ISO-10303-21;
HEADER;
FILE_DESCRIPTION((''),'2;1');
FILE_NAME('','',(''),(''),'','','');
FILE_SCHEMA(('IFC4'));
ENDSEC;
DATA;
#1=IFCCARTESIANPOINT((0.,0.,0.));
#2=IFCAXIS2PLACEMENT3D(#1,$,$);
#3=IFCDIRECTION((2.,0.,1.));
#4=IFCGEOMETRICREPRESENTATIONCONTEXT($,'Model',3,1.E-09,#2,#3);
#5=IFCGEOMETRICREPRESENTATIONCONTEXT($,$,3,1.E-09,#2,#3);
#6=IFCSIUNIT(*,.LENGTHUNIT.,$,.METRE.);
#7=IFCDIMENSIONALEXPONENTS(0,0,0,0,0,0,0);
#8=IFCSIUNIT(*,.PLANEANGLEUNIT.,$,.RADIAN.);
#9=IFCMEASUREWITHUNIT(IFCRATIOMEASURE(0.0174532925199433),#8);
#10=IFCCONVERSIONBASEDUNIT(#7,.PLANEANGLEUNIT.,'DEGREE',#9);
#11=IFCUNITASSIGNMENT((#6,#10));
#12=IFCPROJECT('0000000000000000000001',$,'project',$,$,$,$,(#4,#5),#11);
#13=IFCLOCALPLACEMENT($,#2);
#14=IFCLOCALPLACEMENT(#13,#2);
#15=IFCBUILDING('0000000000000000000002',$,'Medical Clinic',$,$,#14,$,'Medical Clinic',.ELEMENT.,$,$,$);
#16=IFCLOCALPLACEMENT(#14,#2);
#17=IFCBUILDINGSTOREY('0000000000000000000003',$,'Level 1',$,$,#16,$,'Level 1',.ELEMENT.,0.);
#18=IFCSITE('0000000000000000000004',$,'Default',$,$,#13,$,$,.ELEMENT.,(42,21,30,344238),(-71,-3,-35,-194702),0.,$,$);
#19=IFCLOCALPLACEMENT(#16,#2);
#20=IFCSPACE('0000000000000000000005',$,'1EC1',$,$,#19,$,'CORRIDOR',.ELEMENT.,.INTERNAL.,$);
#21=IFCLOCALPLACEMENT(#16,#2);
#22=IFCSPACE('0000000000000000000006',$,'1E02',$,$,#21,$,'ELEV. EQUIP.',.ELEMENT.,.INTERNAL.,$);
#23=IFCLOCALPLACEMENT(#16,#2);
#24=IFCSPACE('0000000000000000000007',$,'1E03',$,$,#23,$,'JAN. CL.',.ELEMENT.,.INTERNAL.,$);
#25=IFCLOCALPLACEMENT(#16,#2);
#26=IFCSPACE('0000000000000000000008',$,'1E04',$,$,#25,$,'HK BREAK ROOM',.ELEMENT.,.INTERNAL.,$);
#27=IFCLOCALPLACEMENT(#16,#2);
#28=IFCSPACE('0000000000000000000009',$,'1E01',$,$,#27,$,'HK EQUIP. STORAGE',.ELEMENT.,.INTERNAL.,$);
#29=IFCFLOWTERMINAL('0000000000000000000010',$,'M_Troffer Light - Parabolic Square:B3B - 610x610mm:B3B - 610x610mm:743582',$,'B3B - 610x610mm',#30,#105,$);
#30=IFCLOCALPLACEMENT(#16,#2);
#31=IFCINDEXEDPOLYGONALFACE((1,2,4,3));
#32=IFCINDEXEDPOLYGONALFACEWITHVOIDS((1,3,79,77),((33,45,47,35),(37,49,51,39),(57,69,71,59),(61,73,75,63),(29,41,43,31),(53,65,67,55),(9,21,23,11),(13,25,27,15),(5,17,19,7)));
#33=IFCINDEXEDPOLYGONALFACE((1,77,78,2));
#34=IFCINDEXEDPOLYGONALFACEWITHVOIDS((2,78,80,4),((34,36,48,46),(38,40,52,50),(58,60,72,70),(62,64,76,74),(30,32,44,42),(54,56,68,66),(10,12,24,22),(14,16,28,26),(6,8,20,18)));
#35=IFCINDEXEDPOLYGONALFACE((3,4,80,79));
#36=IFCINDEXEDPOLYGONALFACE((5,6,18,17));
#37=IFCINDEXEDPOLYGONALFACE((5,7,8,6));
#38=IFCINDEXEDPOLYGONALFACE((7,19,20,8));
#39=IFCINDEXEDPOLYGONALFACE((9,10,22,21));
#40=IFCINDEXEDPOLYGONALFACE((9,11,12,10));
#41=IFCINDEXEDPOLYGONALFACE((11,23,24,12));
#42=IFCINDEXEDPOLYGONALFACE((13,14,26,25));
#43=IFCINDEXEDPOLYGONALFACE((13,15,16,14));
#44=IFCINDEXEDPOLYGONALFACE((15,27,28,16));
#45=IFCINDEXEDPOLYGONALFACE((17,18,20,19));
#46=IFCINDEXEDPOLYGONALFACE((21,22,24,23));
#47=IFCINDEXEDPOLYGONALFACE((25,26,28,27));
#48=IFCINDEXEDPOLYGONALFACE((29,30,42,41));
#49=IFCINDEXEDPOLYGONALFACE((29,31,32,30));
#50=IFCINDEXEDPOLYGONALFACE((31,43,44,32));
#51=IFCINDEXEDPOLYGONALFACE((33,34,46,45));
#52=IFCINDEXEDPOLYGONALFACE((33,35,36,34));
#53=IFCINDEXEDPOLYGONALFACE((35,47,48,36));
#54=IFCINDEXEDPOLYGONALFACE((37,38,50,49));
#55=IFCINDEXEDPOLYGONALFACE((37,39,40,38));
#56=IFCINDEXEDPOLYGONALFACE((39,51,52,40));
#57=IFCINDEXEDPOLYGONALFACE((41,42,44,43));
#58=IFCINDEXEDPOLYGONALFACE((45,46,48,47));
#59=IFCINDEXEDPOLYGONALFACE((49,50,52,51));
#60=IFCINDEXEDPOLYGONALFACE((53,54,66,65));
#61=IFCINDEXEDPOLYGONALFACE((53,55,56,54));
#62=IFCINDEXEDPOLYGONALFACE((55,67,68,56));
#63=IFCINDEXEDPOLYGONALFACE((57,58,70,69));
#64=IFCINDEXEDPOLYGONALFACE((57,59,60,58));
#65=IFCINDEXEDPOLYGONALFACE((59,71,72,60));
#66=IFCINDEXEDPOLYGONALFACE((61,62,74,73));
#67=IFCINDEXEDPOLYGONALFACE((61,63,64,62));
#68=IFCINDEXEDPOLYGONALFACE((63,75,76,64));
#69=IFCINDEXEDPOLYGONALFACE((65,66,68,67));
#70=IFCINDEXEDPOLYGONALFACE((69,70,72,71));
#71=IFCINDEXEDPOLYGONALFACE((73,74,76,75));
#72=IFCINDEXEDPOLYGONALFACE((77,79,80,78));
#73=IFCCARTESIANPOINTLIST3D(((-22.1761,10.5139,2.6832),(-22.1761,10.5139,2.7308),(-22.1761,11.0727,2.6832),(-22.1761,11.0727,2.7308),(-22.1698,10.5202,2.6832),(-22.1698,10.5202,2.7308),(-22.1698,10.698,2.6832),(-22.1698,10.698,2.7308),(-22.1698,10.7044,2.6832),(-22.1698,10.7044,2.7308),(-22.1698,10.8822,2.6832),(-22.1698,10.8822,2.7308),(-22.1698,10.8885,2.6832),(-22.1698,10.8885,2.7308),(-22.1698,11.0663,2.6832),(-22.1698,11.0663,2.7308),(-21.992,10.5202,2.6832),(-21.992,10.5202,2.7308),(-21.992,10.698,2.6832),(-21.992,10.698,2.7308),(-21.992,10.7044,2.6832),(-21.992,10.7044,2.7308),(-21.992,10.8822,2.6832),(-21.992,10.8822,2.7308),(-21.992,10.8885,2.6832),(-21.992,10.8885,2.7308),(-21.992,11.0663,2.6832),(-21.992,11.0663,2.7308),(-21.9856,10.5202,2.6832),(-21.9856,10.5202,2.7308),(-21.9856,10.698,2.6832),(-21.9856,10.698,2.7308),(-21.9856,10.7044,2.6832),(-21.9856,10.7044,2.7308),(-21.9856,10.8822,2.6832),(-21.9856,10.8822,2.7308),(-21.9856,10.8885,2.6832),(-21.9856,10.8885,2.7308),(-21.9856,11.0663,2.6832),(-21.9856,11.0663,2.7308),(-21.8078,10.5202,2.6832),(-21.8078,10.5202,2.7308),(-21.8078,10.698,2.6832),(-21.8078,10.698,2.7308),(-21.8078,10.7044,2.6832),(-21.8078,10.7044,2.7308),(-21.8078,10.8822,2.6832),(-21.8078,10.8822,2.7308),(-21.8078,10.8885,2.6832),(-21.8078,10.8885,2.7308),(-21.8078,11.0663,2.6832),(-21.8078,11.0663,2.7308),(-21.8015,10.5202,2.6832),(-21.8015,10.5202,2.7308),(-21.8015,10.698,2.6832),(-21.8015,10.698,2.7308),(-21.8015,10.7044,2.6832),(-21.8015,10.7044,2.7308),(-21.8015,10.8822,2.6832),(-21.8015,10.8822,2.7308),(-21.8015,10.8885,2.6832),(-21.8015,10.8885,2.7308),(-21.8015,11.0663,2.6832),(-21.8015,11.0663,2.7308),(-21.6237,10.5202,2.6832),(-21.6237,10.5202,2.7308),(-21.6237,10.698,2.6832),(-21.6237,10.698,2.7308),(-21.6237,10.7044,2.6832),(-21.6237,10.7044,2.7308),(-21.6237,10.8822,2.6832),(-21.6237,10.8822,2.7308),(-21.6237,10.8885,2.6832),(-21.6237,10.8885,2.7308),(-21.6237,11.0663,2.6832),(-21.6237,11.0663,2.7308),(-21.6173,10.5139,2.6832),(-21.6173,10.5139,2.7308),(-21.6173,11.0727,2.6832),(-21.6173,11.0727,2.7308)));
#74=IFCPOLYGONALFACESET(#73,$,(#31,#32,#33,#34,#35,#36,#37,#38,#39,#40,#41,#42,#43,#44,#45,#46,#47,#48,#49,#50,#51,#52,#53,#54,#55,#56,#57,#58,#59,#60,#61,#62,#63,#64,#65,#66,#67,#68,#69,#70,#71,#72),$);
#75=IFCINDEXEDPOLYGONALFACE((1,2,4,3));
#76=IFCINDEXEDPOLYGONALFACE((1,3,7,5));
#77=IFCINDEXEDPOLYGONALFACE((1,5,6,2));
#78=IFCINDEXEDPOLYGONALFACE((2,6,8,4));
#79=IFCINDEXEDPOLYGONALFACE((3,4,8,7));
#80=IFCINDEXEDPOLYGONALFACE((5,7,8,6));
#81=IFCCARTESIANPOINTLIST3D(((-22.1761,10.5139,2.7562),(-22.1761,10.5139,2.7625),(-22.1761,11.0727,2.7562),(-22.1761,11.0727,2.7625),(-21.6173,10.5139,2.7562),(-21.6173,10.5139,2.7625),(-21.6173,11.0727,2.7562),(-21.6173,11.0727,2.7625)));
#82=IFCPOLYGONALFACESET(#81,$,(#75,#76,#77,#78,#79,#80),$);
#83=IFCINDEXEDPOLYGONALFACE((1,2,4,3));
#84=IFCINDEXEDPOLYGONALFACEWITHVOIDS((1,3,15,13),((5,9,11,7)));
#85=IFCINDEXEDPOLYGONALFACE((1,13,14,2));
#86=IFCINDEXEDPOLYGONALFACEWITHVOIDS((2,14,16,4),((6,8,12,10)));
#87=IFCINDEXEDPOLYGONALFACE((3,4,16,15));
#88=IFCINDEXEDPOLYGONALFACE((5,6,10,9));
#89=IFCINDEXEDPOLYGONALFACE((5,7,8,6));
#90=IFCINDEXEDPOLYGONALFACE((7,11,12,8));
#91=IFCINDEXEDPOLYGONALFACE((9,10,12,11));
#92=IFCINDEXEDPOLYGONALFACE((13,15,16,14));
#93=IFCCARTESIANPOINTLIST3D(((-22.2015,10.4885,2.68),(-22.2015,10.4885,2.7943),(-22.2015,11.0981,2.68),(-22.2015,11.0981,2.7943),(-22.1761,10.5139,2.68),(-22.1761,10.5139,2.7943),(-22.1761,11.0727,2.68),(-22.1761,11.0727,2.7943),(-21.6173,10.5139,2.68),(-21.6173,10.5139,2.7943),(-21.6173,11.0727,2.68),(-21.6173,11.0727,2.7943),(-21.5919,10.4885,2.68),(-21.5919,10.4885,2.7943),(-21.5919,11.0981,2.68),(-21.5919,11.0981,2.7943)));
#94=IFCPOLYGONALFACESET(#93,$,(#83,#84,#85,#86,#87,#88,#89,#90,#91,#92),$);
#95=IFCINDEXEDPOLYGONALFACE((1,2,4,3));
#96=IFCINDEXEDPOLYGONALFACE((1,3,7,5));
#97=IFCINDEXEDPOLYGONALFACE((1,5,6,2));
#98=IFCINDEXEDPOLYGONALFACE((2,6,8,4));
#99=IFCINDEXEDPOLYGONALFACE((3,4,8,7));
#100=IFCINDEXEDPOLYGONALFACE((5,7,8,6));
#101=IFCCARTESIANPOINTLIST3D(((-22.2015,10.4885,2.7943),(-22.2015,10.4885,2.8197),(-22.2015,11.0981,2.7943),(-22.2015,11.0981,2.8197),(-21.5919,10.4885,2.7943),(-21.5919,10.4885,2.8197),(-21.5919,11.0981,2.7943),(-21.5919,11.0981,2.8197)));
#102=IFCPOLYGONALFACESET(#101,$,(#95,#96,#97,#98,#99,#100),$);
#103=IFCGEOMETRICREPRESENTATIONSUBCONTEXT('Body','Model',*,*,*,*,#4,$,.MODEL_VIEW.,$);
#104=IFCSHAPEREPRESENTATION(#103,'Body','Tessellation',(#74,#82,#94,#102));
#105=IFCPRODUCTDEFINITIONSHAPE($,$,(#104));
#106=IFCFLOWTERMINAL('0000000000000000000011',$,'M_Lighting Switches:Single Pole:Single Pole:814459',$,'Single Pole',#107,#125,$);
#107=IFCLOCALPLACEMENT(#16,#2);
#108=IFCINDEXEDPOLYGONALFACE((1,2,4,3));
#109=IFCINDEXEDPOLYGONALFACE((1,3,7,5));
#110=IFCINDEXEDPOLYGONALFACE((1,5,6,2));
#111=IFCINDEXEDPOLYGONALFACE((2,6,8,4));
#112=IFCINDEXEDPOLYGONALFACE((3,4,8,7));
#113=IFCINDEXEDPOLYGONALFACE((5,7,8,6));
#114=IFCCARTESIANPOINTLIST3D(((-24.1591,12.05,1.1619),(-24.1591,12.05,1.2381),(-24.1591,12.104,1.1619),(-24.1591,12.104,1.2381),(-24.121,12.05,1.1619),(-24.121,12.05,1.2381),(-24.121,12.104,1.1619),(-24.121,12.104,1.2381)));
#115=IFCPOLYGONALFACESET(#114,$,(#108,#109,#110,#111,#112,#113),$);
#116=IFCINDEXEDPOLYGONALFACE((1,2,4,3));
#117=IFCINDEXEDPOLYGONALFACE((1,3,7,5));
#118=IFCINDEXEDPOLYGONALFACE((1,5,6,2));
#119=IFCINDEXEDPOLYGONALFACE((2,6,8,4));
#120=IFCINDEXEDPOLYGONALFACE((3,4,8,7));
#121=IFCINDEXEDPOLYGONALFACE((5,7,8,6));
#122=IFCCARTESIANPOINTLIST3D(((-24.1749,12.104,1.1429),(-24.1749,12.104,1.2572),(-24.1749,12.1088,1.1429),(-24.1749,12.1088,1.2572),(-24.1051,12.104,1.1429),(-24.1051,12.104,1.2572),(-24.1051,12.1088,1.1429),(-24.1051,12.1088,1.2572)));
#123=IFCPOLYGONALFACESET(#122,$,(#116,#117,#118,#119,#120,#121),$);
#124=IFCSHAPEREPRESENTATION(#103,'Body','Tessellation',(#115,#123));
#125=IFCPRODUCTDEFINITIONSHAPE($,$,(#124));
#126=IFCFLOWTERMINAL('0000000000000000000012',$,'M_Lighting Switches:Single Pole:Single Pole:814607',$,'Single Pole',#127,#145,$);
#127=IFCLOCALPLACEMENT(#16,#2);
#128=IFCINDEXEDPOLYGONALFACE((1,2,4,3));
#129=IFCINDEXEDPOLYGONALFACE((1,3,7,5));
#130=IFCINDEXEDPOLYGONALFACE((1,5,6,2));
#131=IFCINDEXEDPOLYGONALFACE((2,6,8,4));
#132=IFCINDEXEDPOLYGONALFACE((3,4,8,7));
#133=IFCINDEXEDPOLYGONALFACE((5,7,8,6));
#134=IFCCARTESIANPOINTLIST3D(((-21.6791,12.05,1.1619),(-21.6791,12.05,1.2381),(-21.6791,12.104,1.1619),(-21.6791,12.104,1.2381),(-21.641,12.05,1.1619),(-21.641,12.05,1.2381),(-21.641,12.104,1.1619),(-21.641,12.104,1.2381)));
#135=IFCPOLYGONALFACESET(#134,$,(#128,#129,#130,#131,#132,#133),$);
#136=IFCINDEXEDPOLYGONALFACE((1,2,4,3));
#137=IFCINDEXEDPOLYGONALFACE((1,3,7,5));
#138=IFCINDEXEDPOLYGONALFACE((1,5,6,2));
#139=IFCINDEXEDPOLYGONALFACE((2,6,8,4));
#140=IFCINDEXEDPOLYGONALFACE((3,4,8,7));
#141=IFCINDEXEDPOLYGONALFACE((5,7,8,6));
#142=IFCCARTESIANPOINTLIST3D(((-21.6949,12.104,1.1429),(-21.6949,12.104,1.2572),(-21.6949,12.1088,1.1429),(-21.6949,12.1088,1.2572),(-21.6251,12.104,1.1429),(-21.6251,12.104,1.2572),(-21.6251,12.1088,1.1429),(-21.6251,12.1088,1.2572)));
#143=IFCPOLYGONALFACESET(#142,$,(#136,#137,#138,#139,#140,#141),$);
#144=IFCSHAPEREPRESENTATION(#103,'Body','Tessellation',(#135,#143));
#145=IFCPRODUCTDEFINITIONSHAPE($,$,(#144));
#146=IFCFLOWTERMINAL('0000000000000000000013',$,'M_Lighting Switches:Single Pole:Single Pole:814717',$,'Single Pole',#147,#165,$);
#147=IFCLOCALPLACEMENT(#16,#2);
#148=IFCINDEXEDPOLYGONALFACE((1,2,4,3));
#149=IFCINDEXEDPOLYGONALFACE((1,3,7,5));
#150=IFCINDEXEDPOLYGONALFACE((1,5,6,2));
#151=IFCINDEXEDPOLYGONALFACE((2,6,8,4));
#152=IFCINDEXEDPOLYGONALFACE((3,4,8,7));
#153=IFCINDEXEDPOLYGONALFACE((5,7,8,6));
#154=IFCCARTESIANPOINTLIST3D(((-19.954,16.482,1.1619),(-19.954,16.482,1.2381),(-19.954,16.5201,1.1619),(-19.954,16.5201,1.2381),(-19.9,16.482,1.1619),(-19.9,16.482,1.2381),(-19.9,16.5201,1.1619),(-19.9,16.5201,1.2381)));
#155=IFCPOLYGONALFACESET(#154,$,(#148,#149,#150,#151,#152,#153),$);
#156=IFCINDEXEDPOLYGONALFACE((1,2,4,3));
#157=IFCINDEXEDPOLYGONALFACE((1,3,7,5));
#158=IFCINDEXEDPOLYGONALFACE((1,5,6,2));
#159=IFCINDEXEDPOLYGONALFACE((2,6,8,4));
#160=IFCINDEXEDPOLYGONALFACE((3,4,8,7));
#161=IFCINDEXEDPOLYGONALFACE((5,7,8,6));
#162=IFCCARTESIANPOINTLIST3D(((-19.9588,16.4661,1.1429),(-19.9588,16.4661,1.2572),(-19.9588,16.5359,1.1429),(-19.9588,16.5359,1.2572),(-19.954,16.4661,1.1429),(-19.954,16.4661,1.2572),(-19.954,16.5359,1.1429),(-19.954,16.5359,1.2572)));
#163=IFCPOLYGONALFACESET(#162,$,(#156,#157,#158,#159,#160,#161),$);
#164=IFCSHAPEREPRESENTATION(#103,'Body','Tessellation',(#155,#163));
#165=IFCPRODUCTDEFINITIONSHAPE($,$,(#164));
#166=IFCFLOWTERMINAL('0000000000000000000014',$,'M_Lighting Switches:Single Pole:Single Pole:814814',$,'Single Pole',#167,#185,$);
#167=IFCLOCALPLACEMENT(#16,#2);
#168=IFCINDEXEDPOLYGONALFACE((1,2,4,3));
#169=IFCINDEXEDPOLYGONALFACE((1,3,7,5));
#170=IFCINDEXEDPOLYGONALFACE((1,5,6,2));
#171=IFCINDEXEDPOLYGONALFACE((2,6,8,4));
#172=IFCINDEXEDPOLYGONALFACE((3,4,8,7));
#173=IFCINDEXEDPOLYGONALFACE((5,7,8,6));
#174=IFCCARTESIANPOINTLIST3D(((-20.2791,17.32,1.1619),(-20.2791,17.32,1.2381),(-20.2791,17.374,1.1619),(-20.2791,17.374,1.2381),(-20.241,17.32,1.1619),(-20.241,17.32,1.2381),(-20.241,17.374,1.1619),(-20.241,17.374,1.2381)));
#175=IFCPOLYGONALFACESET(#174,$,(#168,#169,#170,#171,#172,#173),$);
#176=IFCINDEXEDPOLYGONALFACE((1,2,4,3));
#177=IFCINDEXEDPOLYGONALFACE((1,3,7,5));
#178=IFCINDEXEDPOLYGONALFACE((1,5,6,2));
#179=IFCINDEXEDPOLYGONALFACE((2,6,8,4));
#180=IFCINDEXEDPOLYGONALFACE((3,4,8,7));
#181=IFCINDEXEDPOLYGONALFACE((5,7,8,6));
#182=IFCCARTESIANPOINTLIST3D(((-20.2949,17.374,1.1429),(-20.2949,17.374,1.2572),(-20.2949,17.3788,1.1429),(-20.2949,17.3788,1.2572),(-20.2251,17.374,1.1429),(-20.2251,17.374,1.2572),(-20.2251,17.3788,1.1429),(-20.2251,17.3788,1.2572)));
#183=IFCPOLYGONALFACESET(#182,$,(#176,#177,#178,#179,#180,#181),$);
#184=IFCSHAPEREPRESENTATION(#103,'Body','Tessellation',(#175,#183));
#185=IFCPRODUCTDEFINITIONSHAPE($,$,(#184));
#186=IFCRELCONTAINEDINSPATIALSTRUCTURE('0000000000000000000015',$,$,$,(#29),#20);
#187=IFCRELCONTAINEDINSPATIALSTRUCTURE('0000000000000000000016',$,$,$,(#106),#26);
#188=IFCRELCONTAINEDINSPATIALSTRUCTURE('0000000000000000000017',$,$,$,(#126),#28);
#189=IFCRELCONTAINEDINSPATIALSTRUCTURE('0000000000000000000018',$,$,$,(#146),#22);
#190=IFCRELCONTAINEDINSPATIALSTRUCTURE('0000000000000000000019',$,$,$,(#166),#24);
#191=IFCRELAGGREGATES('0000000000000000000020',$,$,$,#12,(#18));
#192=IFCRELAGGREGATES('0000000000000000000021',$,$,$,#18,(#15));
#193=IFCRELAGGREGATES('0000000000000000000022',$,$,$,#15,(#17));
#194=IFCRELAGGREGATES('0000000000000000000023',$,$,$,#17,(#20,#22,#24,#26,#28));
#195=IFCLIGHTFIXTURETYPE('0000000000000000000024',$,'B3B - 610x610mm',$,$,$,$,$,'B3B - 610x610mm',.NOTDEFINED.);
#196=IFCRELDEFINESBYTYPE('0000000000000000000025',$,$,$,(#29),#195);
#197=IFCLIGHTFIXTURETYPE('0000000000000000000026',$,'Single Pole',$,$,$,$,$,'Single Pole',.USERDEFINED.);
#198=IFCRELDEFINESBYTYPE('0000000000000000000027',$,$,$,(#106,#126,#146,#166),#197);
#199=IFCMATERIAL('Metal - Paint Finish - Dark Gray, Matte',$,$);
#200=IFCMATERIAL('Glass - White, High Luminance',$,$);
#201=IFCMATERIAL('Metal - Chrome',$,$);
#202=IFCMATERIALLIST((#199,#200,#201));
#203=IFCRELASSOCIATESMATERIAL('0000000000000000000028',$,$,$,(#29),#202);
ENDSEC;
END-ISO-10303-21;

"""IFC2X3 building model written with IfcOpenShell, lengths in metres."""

from ifc_helpers import new_model, entity, si_unit, converted_unit, direction, frame, frame_2d, origin, origin_2d_with_axis, place, context, subcontext, project, spatial, polyline, rectangle, outline, extrude, source, transform, mapped, material, material_list, type_object, type_shapes, element, save


model = new_model("IFC2X3")

# Units and contexts
model_context = context("Model", 3, precision=1e-09, world=origin(), true_north=direction((2.0, 0.0, 1.0)))
context_of_model = context(None, 3, precision=1e-09, world=origin(), true_north=direction((2.0, 0.0, 1.0)))
body_context = subcontext(model_context, "Body", "Model", "MODEL_VIEW")
ifc_project = project(units=[si_unit("LENGTHUNIT", "METRE"), converted_unit("PLANEANGLEUNIT", "DEGREE", entity("IfcRatioMeasure", 0.0174532925199433), si_unit("PLANEANGLEUNIT", "RADIAN"), dimensions=[0, 0, 0, 0, 0, 0, 0])], contexts=[model_context, context_of_model])

# Site, building, storey, space
site_placement = place(None, origin())
site = spatial("IfcSite", under=ifc_project, at=site_placement, Name="Default", CompositionType="ELEMENT", RefLatitude=(42, 21, 30, 344238), RefLongitude=(-71, -3, -35, -194702), RefElevation=0.0)
building_placement = place(site_placement, origin())
building = spatial("IfcBuilding", under=site, at=building_placement, Name="Medical Clinic", LongName="Medical Clinic", CompositionType="ELEMENT")
storey_placement = place(building_placement, origin())
storey = spatial("IfcBuildingStorey", under=building, at=storey_placement, Name="Level 1", LongName="Level 1", CompositionType="ELEMENT", Elevation=0.0)
space_1_placement = place(storey_placement, origin())
space_1 = spatial("IfcSpace", under=storey, at=space_1_placement, Name="1EC1", LongName="CORRIDOR", CompositionType="ELEMENT", InteriorOrExteriorSpace="INTERNAL")

# Shared definitions
ifc_material_1 = material(Name="Metal - Paint Finish - Dark Gray, Matte")
ifc_material_2 = material(Name="Glass - White, High Luminance")
ifc_material_3 = material(Name="Metal - Chrome")

# Flow terminal
ifc_material_list_1 = material_list([ifc_material_1, ifc_material_2, ifc_material_3])
light_fixture_type_1 = type_object("IfcLightFixtureType", Name="B3B - 610x610mm", ElementType="B3B - 610x610mm", PredefinedType="NOTDEFINED")
shared_shape_1 = source(origin(), body_context, "Body", "SweptSolid", [
    extrude(outline(polyline([(-0.2794, -0.2794), (0.2794, -0.2794), (0.2794, 0.2794), (-0.2794, 0.2794), (-0.2794, -0.2794)]), holes=[polyline([(-0.0952, 0.0953), (-0.273, 0.0953), (-0.273, 0.2731), (-0.0952, 0.2731), (-0.0952, 0.0953)]), polyline([(0.2731, 0.0953), (0.0953, 0.0953), (0.0953, 0.2731), (0.2731, 0.2731), (0.2731, 0.0953)]), polyline([(-0.0889, 0.2731), (0.0889, 0.2731), (0.0889, 0.0953), (-0.0889, 0.0953), (-0.0889, 0.2731)]), polyline([(0.2731, -0.273), (0.0953, -0.273), (0.0953, -0.0952), (0.2731, -0.0952), (0.2731, -0.273)]), polyline([(0.0889, -0.273), (-0.0889, -0.273), (-0.0889, -0.0952), (0.0889, -0.0952), (0.0889, -0.273)]), polyline([(-0.0952, -0.273), (-0.273, -0.273), (-0.273, -0.0952), (-0.0952, -0.0952), (-0.0952, -0.273)]), polyline([(-0.0952, -0.0889), (-0.273, -0.0889), (-0.273, 0.0889), (-0.0952, 0.0889), (-0.0952, -0.0889)]), polyline([(0.0889, -0.0889), (-0.0889, -0.0889), (-0.0889, 0.0889), (0.0889, 0.0889), (0.0889, -0.0889)]), polyline([(0.2731, -0.0889), (0.0953, -0.0889), (0.0953, 0.0889), (0.2731, 0.0889), (0.2731, -0.0889)])]), frame((0.0, -0.3048, -0.0508), z_axis=(0.0, 0.0, 1.0), x_axis=(-1.0, 0.0, 0.0)), (0.0, 0.0, 1.0), 0.0476),
    extrude(rectangle(XDim=0.5588, YDim=0.5588, at=origin_2d_with_axis()), frame((0.0, -0.3048, -0.0825), z_axis=(0.0, 0.0, 1.0), x_axis=(-1.0, 0.0, 0.0)), (0.0, 0.0, 1.0), 0.0064),
    extrude(outline(polyline([(-0.3048, -0.3048), (0.3048, -0.3048), (0.3048, 0.3048), (-0.3048, 0.3048), (-0.3048, -0.3048)]), holes=[polyline([(0.2794, 0.2794), (0.2794, -0.2794), (-0.2794, -0.2794), (-0.2794, 0.2794), (0.2794, 0.2794)])]), frame((0.0, -0.3048, -0.1143)), (0.0, 0.0, 1.0), 0.1143),
    extrude(rectangle(XDim=0.6096, YDim=0.6096, at=origin_2d_with_axis()), frame((0.0, -0.3048, -0.1397), z_axis=(0.0, 0.0, 1.0), x_axis=(-1.0, 0.0, 0.0)), (0.0, 0.0, 1.0), 0.0254),
])
type_shapes(light_fixture_type_1, [shared_shape_1])
flow_terminal_1_placement = place(space_1_placement, frame((-21.8967, 10.4885, 2.68), z_axis=(0.0, 0.0, -1.0), x_axis=(1.0, 0.0, 0.0)))
element("IfcFlowTerminal", 1, at=flow_terminal_1_placement, inside=space_1, type_object=light_fixture_type_1, material=ifc_material_list_1, Name="M_Troffer Light - Parabolic Square:B3B - 610x610mm:B3B - 610x610mm:743582", ObjectType="B3B - 610x610mm", context=body_context, shape_type="MappedRepresentation", body=[
    mapped(shared_shape_1, transform((0.0, 0.0, 0.0), scale=1.0)),
])

# Shared definitions
space_2_placement = place(storey_placement, origin())
space_2 = spatial("IfcSpace", under=storey, at=space_2_placement, Name="1E02", LongName="ELEV. EQUIP.", CompositionType="ELEMENT", InteriorOrExteriorSpace="INTERNAL")

# Shared definitions
space_3_placement = place(storey_placement, origin())
space_3 = spatial("IfcSpace", under=storey, at=space_3_placement, Name="1E03", LongName="JAN. CL.", CompositionType="ELEMENT", InteriorOrExteriorSpace="INTERNAL")

# Shared definitions
space_4_placement = place(storey_placement, origin())
space_4 = spatial("IfcSpace", under=storey, at=space_4_placement, Name="1E04", LongName="HK BREAK ROOM", CompositionType="ELEMENT", InteriorOrExteriorSpace="INTERNAL")

# Flow terminal
light_fixture_type_2 = type_object("IfcLightFixtureType", Name="Single Pole", ElementType="Single Pole", PredefinedType="USERDEFINED")
shared_shape_2 = source(origin(), body_context, "Body", "SweptSolid", [
    extrude(rectangle(XDim=0.0381, YDim=0.0762, at=origin_2d_with_axis()), frame((0.0, 0.0, -0.054), z_axis=(0.0, 0.0, 1.0), x_axis=(-1.0, 0.0, 0.0)), (0.0, 0.0, 1.0), 0.054),
    extrude(rectangle(XDim=0.0698, YDim=0.1143, at=frame_2d((0.0, 0.0), x_axis=(1.0, 0.0))), frame((0.0, 0.0, 0.0), z_axis=(0.0, 0.0, 1.0), x_axis=(-1.0, 0.0, 0.0)), (0.0, 0.0, 1.0), 0.0048),
])
type_shapes(light_fixture_type_2, [shared_shape_2])
flow_terminal_2_placement = place(space_4_placement, frame((-24.14, 12.104, 1.2), z_axis=(0.0, 1.0, 0.0), x_axis=(-1.0, 0.0, 0.0)))
element("IfcFlowTerminal", 2, at=flow_terminal_2_placement, inside=space_4, type_object=light_fixture_type_2, Name="M_Lighting Switches:Single Pole:Single Pole:814459", ObjectType="Single Pole", context=body_context, shape_type="MappedRepresentation", body=[
    mapped(shared_shape_2, transform((0.0, 0.0, 0.0), scale=1.0)),
])

# Shared definitions
space_5_placement = place(storey_placement, origin())
space_5 = spatial("IfcSpace", under=storey, at=space_5_placement, Name="1E01", LongName="HK EQUIP. STORAGE", CompositionType="ELEMENT", InteriorOrExteriorSpace="INTERNAL")

# Flow terminals
flow_terminal_3_placement = place(space_5_placement, frame((-21.66, 12.104, 1.2), z_axis=(0.0, 1.0, 0.0), x_axis=(-1.0, 0.0, 0.0)))
element("IfcFlowTerminal", 3, at=flow_terminal_3_placement, inside=space_5, type_object=light_fixture_type_2, Name="M_Lighting Switches:Single Pole:Single Pole:814607", ObjectType="Single Pole", context=body_context, shape_type="MappedRepresentation", body=[
    mapped(shared_shape_2, transform((0.0, 0.0, 0.0), scale=1.0)),
])
flow_terminal_4_placement = place(space_2_placement, frame((-19.954, 16.501, 1.2), z_axis=(-1.0, 0.0, 0.0), x_axis=(0.0, -1.0, 0.0)))
element("IfcFlowTerminal", 4, at=flow_terminal_4_placement, inside=space_2, type_object=light_fixture_type_2, Name="M_Lighting Switches:Single Pole:Single Pole:814717", ObjectType="Single Pole", context=body_context, shape_type="MappedRepresentation", body=[
    mapped(shared_shape_2, transform((0.0, 0.0, 0.0), scale=1.0)),
])
flow_terminal_5_placement = place(space_3_placement, frame((-20.26, 17.374, 1.2), z_axis=(0.0, 1.0, 0.0), x_axis=(-1.0, 0.0, 0.0)))
element("IfcFlowTerminal", 5, at=flow_terminal_5_placement, inside=space_3, type_object=light_fixture_type_2, Name="M_Lighting Switches:Single Pole:Single Pole:814814", ObjectType="Single Pole", context=body_context, shape_type="MappedRepresentation", body=[
    mapped(shared_shape_2, transform((0.0, 0.0, 0.0), scale=1.0)),
])

save(model, "model.ifc")
